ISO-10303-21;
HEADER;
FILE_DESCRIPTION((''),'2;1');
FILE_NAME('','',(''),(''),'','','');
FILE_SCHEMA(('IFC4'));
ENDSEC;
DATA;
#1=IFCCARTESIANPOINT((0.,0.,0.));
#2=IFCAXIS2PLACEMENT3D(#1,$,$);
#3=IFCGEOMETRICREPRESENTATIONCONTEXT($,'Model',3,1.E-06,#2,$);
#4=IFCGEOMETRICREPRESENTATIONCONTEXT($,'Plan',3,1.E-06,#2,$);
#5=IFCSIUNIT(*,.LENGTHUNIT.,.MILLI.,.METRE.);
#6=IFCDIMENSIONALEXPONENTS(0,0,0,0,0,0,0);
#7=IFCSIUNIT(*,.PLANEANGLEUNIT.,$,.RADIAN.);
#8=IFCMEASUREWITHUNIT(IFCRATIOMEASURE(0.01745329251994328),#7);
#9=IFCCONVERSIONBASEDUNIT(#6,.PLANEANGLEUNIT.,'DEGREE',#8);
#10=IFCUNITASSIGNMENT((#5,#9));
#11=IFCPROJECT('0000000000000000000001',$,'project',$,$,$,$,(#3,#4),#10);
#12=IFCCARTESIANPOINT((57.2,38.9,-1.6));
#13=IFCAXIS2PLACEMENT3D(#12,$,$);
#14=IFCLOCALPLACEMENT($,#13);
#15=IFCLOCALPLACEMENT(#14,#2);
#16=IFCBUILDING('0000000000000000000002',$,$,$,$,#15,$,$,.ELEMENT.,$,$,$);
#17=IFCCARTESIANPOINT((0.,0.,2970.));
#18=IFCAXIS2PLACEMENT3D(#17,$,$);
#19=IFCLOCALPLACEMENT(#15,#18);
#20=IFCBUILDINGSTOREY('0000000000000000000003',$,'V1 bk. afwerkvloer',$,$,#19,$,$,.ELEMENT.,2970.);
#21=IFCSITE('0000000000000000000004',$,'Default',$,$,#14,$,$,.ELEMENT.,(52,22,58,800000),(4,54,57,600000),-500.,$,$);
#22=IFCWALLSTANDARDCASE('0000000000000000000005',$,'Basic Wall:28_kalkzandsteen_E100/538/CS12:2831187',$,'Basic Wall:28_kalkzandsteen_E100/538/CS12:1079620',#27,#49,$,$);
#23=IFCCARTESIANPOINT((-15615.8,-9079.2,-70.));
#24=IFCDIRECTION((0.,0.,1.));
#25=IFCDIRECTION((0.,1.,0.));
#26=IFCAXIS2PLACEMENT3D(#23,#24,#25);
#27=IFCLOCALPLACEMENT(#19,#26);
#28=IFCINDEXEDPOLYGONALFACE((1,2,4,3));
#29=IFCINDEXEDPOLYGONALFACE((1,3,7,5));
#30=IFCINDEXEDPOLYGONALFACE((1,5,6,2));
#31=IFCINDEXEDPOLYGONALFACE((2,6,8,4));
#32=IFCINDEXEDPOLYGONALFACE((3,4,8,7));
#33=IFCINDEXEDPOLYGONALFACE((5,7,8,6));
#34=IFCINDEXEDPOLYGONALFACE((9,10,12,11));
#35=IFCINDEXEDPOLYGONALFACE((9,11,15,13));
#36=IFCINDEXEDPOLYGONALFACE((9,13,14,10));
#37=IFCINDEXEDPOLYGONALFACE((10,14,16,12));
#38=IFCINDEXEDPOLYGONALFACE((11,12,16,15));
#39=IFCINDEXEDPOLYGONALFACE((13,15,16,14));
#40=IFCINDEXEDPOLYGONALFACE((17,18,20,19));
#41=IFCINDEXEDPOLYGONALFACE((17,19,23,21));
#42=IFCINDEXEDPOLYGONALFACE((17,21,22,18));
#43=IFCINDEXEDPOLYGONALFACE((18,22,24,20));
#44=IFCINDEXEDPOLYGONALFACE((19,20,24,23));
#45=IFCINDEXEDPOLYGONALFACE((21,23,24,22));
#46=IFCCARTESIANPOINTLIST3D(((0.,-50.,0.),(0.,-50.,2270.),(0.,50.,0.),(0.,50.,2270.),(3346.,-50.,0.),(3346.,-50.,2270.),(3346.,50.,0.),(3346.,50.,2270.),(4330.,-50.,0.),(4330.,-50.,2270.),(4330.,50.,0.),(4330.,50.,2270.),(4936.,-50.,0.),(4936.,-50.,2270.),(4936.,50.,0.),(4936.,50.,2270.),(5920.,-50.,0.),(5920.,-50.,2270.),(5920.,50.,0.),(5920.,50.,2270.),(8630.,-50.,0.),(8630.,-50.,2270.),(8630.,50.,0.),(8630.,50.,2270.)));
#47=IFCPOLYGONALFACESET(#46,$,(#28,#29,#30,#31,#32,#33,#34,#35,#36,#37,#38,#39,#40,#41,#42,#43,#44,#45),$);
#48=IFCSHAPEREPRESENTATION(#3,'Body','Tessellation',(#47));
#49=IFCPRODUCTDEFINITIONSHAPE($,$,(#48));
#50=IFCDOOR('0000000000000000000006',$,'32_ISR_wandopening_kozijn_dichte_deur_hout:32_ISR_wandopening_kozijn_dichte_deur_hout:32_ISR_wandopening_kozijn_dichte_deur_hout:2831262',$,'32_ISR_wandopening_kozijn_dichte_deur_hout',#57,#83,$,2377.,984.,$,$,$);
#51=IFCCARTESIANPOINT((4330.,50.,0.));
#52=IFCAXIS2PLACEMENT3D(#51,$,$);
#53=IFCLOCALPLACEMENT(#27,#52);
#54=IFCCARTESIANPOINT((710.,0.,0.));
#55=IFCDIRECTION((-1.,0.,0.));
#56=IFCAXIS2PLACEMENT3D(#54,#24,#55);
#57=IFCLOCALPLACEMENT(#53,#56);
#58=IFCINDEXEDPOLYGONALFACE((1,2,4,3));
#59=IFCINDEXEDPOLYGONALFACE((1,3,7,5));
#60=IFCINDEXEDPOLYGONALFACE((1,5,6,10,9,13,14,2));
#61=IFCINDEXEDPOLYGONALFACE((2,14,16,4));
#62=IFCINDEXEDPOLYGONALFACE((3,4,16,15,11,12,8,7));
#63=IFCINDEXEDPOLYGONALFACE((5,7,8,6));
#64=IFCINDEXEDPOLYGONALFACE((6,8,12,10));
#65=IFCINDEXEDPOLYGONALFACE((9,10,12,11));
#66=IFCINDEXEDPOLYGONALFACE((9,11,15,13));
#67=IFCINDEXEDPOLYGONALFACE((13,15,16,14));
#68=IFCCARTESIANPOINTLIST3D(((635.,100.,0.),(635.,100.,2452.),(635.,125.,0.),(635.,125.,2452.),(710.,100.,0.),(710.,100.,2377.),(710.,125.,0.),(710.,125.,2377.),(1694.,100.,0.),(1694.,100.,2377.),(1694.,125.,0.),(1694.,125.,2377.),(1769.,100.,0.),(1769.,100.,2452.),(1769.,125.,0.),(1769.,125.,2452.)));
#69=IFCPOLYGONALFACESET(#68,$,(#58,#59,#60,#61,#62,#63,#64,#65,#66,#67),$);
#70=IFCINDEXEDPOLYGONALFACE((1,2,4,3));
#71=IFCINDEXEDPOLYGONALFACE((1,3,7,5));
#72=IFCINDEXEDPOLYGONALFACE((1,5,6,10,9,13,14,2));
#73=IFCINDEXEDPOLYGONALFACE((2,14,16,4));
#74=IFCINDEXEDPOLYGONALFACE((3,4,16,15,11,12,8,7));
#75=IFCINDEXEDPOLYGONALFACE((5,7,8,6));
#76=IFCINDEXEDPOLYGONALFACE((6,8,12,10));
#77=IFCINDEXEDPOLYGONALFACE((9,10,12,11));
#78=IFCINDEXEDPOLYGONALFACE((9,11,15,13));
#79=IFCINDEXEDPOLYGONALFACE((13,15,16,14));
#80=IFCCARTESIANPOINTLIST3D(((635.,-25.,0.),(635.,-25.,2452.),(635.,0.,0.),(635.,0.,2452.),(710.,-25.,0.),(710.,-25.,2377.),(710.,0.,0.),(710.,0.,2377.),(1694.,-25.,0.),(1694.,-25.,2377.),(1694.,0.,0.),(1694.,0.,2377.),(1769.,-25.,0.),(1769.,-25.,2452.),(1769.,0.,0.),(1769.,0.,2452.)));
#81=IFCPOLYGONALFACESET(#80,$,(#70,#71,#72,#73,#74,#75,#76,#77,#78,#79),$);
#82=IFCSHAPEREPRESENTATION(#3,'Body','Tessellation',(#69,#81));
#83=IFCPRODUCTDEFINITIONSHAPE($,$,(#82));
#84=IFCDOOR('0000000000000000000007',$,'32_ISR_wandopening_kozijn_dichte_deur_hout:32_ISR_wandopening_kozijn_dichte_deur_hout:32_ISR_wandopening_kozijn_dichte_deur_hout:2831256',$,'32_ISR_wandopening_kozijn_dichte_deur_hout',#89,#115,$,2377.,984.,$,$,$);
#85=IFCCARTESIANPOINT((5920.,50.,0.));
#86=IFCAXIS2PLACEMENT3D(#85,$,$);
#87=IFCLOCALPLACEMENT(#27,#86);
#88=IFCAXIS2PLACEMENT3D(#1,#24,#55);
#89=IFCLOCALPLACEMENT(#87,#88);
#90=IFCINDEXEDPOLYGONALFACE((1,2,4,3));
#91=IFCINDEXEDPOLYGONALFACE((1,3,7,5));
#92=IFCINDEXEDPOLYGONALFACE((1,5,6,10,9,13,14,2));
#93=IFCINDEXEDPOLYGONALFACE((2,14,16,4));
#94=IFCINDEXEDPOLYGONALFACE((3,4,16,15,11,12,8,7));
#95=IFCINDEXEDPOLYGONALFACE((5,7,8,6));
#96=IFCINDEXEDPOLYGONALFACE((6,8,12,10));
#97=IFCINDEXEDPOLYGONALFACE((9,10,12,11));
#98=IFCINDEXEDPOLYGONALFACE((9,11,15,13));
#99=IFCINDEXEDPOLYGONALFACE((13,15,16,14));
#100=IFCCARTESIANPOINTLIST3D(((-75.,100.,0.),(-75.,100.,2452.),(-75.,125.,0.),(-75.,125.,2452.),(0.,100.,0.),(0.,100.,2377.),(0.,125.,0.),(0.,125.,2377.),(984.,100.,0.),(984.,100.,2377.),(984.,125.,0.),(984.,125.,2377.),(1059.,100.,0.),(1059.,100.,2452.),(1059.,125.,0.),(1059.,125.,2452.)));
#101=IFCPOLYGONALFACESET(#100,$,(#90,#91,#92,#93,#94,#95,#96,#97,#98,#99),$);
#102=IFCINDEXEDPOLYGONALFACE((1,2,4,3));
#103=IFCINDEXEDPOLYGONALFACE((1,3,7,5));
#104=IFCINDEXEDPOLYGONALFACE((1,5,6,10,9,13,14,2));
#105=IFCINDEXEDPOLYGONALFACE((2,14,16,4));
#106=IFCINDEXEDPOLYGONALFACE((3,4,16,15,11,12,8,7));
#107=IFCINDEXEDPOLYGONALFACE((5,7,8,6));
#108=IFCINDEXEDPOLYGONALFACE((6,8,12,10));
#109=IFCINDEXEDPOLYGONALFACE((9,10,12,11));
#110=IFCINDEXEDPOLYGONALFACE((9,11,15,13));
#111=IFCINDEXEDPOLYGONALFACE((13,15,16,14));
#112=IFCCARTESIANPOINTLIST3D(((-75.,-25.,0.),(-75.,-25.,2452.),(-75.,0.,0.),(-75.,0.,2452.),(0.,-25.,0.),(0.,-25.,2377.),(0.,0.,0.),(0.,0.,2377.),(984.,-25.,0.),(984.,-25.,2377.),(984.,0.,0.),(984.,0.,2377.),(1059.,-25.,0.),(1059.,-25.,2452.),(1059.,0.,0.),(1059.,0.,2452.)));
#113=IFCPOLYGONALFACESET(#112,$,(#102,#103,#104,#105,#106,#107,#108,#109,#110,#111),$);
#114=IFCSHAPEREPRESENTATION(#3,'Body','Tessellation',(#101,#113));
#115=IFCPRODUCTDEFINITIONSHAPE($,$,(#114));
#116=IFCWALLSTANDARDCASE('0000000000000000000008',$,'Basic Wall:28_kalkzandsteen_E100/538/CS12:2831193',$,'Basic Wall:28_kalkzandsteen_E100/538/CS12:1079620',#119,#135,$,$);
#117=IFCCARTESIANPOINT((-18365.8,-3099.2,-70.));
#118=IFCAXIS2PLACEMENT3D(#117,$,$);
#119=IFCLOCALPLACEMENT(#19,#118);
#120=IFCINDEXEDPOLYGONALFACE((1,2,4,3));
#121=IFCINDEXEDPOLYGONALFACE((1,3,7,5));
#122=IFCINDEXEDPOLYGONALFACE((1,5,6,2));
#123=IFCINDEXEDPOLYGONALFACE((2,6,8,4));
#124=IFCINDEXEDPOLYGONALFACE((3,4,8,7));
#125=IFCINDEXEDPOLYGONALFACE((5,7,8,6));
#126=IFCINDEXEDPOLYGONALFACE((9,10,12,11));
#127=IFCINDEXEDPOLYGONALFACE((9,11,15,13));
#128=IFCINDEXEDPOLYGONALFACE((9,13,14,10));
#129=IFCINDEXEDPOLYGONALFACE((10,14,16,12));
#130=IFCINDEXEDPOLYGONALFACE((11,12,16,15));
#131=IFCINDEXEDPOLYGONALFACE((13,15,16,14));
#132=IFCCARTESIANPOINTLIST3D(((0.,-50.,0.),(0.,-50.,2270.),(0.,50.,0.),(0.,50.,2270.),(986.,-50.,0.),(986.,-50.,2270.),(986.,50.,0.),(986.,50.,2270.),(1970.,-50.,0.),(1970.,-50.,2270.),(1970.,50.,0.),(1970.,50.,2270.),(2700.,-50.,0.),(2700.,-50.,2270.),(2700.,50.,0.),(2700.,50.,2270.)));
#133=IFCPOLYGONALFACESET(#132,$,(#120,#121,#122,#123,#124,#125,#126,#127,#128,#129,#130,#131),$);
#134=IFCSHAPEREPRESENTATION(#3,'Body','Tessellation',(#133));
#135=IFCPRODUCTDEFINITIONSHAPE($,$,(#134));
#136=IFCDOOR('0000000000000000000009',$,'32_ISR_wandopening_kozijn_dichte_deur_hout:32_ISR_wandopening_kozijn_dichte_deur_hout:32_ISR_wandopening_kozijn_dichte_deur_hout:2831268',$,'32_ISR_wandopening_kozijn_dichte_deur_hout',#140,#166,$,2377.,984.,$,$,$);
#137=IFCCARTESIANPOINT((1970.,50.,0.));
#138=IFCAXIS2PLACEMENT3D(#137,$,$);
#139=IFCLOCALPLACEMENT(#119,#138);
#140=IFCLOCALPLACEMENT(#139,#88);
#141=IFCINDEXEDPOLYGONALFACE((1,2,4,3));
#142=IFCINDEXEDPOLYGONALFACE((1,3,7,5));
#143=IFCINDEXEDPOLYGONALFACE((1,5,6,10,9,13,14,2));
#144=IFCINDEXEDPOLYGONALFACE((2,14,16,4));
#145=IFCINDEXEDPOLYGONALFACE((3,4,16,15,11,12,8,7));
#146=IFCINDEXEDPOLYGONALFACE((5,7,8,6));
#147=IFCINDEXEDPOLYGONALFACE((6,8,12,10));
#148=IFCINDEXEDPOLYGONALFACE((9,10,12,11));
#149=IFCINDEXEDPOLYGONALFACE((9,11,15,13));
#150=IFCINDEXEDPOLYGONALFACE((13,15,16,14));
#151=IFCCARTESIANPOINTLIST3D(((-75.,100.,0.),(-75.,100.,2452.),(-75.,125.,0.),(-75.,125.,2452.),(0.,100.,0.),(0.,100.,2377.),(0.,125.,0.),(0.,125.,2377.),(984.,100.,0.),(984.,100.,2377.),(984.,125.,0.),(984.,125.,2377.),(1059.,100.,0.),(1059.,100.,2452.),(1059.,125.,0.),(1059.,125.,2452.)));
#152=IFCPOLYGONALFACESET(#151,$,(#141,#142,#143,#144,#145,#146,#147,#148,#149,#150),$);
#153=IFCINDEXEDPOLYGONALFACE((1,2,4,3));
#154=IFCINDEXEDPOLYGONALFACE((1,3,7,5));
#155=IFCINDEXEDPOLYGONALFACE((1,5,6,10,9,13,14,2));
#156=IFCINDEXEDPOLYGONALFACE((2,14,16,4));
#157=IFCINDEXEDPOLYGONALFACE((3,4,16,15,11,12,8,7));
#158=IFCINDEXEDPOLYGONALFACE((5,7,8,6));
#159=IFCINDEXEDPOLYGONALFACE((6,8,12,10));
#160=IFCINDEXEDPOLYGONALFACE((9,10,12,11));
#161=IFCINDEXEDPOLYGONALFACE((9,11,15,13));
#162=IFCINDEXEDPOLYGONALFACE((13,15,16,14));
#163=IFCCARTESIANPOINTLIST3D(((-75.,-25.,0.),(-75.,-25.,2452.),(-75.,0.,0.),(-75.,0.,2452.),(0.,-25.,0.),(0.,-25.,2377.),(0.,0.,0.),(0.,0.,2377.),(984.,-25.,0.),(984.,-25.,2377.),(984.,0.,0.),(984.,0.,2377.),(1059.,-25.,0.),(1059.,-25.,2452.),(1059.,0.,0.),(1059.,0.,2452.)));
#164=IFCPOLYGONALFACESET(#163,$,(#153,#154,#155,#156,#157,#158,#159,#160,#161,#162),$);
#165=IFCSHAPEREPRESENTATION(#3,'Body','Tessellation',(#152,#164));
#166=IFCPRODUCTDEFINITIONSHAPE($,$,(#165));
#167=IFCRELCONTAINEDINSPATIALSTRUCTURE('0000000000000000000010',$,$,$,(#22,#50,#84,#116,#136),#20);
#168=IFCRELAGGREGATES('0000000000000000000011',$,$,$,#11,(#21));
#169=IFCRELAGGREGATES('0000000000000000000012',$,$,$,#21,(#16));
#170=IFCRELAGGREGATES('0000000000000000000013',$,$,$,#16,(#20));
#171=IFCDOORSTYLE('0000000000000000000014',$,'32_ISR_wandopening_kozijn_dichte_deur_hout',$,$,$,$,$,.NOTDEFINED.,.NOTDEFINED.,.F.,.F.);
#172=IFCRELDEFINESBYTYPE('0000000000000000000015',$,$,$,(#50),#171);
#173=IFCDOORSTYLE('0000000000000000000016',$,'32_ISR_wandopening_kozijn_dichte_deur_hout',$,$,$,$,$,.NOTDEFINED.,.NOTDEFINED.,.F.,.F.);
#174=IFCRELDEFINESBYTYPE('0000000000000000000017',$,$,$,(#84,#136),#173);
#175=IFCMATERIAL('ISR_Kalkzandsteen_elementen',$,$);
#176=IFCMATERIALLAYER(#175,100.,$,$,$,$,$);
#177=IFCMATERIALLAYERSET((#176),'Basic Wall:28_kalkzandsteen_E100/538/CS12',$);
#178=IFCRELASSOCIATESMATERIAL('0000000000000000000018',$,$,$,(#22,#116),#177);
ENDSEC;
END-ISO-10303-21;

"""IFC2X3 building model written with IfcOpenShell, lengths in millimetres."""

from ifc_helpers import new_model, entity, si_unit, converted_unit, frame, frame_2d, origin, place, context, project, spatial, polyline, rectangle, outline, extrude, source, transform, mapped, material, layer, layer_set, layer_usage, type_object, type_shapes, element, fill, save


model = new_model("IFC2X3")

# Units and contexts
model_context = context("Model", 3, precision=1e-06, world=origin())
plan_context = context("Plan", 3, precision=1e-06, world=origin())
ifc_project = project(units=[si_unit("LENGTHUNIT", "METRE", prefix="MILLI"), converted_unit("PLANEANGLEUNIT", "DEGREE", entity("IfcRatioMeasure", 0.01745329251994328), si_unit("PLANEANGLEUNIT", "RADIAN"), dimensions=[0, 0, 0, 0, 0, 0, 0])], contexts=[model_context, plan_context])

# Site, building, storey
site_placement = place(None, frame((57.2, 38.9, -1.6)))
site = spatial("IfcSite", under=ifc_project, at=site_placement, Name="Default", CompositionType="ELEMENT", RefLatitude=(52, 22, 58, 800000), RefLongitude=(4, 54, 57, 600000), RefElevation=-500.0)
building_placement = place(site_placement, origin())
building = spatial("IfcBuilding", under=site, at=building_placement, CompositionType="ELEMENT")
storey_placement = place(building_placement, frame((0.0, 0.0, 2970.0)))
storey = spatial("IfcBuildingStorey", under=building, at=storey_placement, Name="V1 bk. afwerkvloer", CompositionType="ELEMENT", Elevation=2970.0)

# Shared definitions
ifc_material_1 = material(Name="ISR_Kalkzandsteen_elementen")
ifc_layer_1 = layer(ifc_material_1, 100.0)
ifc_layer_set_1 = layer_set([ifc_layer_1], Name="Basic Wall:28_kalkzandsteen_E100/538/CS12")

# Wall, openings, doors
ifc_layer_usage_1 = layer_usage(ifc_layer_set_1, "AXIS2", "NEGATIVE", 50.0)
wall_1_placement = place(storey_placement, frame((-15615.8, -9079.2, -70.0), z_axis=(0.0, 0.0, 1.0), x_axis=(0.0, 1.0, 0.0)))
wall_1 = element("IfcWallStandardCase", 1, at=wall_1_placement, inside=storey, material=ifc_layer_usage_1, Name="Basic Wall:28_kalkzandsteen_E100/538/CS12:2831187", ObjectType="Basic Wall:28_kalkzandsteen_E100/538/CS12:1079620", context=model_context, shape_type="SweptSolid", body=[
    extrude(rectangle(XDim=8630.0, YDim=100.0, at=frame_2d((4315.0, 0.0), x_axis=(-1.0, 0.0))), origin(), (0.0, 0.0, 1.0), 2270.0),
])
opening_1_placement = place(wall_1_placement, frame((5920.0, 50.0, 0.0)))
opening_1 = element("IfcOpeningElement", 2, at=opening_1_placement, cuts=wall_1, ObjectType="Opening", context=model_context, shape_type="SweptSolid", body=[
    extrude(rectangle(XDim=2377.0, YDim=984.0, at=frame_2d((1188.5, 492.0), x_axis=(1.0, 0.0))), frame((0.0, 0.0, 0.0), z_axis=(0.0, -1.0, 0.0), x_axis=(0.0, 0.0, 1.0)), (0.0, 0.0, 1.0), 100.0),
])
opening_2_placement = place(wall_1_placement, frame((4330.0, 50.0, 0.0)))
opening_2 = element("IfcOpeningElement", 3, at=opening_2_placement, cuts=wall_1, ObjectType="Opening", context=model_context, shape_type="SweptSolid", body=[
    extrude(rectangle(XDim=2377.0, YDim=984.0, at=frame_2d((1188.5, 492.0), x_axis=(1.0, 0.0))), frame((0.0, 0.0, 0.0), z_axis=(0.0, -1.0, 0.0), x_axis=(0.0, 0.0, 1.0)), (0.0, 0.0, 1.0), 100.0),
])
door_style_1 = type_object("IfcDoorStyle", Name="32_ISR_wandopening_kozijn_dichte_deur_hout", ConstructionType="NOTDEFINED", OperationType="NOTDEFINED", ParameterTakesPrecedence=False, Sizeable=False)
shared_shape_1 = source(origin(), model_context, "Body", "SweptSolid", [
    extrude(outline(polyline([(-1169.7, 492.0), (1207.2, 492.0), (1207.2, 567.0), (-1244.7, 567.0), (-1244.7, -567.0), (1207.2, -567.0), (1207.2, -492.0), (-1169.7, -492.0), (-1169.7, 492.0)])), frame((1202.0, 125.0, 1207.2), z_axis=(0.0, -1.0, 0.0), x_axis=(0.0, 0.0, -1.0)), (0.0, 0.0, 1.0), 25.0),
    extrude(outline(polyline([(-567.0, -1244.7), (567.0, -1244.7), (567.0, 1207.2), (492.0, 1207.2), (492.0, -1169.7), (-492.0, -1169.7), (-492.0, 1207.2), (-567.0, 1207.2), (-567.0, -1244.7)])), frame((1202.0, 0.0, 1207.2), z_axis=(0.0, -1.0, 0.0), x_axis=(-1.0, 0.0, 0.0)), (0.0, 0.0, 1.0), 25.0),
])
type_shapes(door_style_1, [shared_shape_1])
door_1_placement = place(opening_2_placement, frame((710.0, 0.0, 0.0), z_axis=(0.0, 0.0, 1.0), x_axis=(-1.0, 0.0, 0.0)))
door_1 = element("IfcDoor", 4, at=door_1_placement, inside=storey, type_object=door_style_1, Name="32_ISR_wandopening_kozijn_dichte_deur_hout:32_ISR_wandopening_kozijn_dichte_deur_hout:32_ISR_wandopening_kozijn_dichte_deur_hout:2831262", ObjectType="32_ISR_wandopening_kozijn_dichte_deur_hout", OverallHeight=2377.0, OverallWidth=984.0, context=model_context, shape_type="MappedRepresentation", body=[
    mapped(shared_shape_1, transform((0.0, 0.0, 0.0), scale=1.0)),
])
fill(opening_2, door_1)
door_style_2 = type_object("IfcDoorStyle", Name="32_ISR_wandopening_kozijn_dichte_deur_hout", ConstructionType="NOTDEFINED", OperationType="NOTDEFINED", ParameterTakesPrecedence=False, Sizeable=False)
shared_shape_2 = source(origin(), model_context, "Body", "SweptSolid", [
    extrude(outline(polyline([(-1169.7, 492.0), (1207.2, 492.0), (1207.2, 567.0), (-1244.7, 567.0), (-1244.7, -567.0), (1207.2, -567.0), (1207.2, -492.0), (-1169.7, -492.0), (-1169.7, 492.0)])), frame((492.0, 100.0, 1207.2), z_axis=(0.0, 1.0, 0.0), x_axis=(0.0, 0.0, -1.0)), (0.0, 0.0, 1.0), 25.0),
    extrude(outline(polyline([(-567.0, -1244.7), (567.0, -1244.7), (567.0, 1207.2), (492.0, 1207.2), (492.0, -1169.7), (-492.0, -1169.7), (-492.0, 1207.2), (-567.0, 1207.2), (-567.0, -1244.7)])), frame((492.0, -25.0, 1207.2), z_axis=(0.0, 1.0, 0.0), x_axis=(1.0, 0.0, 0.0)), (0.0, 0.0, 1.0), 25.0),
])
type_shapes(door_style_2, [shared_shape_2])
door_2_placement = place(opening_1_placement, frame((0.0, 0.0, 0.0), z_axis=(0.0, 0.0, 1.0), x_axis=(-1.0, 0.0, 0.0)))
door_2 = element("IfcDoor", 5, at=door_2_placement, inside=storey, type_object=door_style_2, Name="32_ISR_wandopening_kozijn_dichte_deur_hout:32_ISR_wandopening_kozijn_dichte_deur_hout:32_ISR_wandopening_kozijn_dichte_deur_hout:2831256", ObjectType="32_ISR_wandopening_kozijn_dichte_deur_hout", OverallHeight=2377.0, OverallWidth=984.0, context=model_context, shape_type="MappedRepresentation", body=[
    mapped(shared_shape_2, transform((0.0, 0.0, 0.0), scale=1.0)),
])
fill(opening_1, door_2)

# Wall, opening, door
ifc_layer_usage_2 = layer_usage(ifc_layer_set_1, "AXIS2", "POSITIVE", -50.0)
wall_2_placement = place(storey_placement, frame((-18365.8, -3099.2, -70.0)))
wall_2 = element("IfcWallStandardCase", 6, at=wall_2_placement, inside=storey, material=ifc_layer_usage_2, Name="Basic Wall:28_kalkzandsteen_E100/538/CS12:2831193", ObjectType="Basic Wall:28_kalkzandsteen_E100/538/CS12:1079620", context=model_context, shape_type="SweptSolid", body=[
    extrude(rectangle(XDim=2700.0, YDim=100.0, at=frame_2d((1350.0, 0.0), x_axis=(-1.0, 0.0))), origin(), (0.0, 0.0, 1.0), 2270.0),
])
opening_3_placement = place(wall_2_placement, frame((1970.0, 50.0, 0.0)))
opening_3 = element("IfcOpeningElement", 7, at=opening_3_placement, cuts=wall_2, ObjectType="Opening", context=model_context, shape_type="SweptSolid", body=[
    extrude(rectangle(XDim=2377.0, YDim=984.0, at=frame_2d((1188.5, 492.0), x_axis=(1.0, 0.0))), frame((0.0, 0.0, 0.0), z_axis=(0.0, -1.0, 0.0), x_axis=(0.0, 0.0, 1.0)), (0.0, 0.0, 1.0), 100.0),
])
door_3_placement = place(opening_3_placement, frame((0.0, 0.0, 0.0), z_axis=(0.0, 0.0, 1.0), x_axis=(-1.0, 0.0, 0.0)))
door_3 = element("IfcDoor", 8, at=door_3_placement, inside=storey, type_object=door_style_2, Name="32_ISR_wandopening_kozijn_dichte_deur_hout:32_ISR_wandopening_kozijn_dichte_deur_hout:32_ISR_wandopening_kozijn_dichte_deur_hout:2831268", ObjectType="32_ISR_wandopening_kozijn_dichte_deur_hout", OverallHeight=2377.0, OverallWidth=984.0, context=model_context, shape_type="MappedRepresentation", body=[
    mapped(shared_shape_2, transform((0.0, 0.0, 0.0), scale=1.0)),
])
fill(opening_3, door_3)

save(model, "model.ifc")
